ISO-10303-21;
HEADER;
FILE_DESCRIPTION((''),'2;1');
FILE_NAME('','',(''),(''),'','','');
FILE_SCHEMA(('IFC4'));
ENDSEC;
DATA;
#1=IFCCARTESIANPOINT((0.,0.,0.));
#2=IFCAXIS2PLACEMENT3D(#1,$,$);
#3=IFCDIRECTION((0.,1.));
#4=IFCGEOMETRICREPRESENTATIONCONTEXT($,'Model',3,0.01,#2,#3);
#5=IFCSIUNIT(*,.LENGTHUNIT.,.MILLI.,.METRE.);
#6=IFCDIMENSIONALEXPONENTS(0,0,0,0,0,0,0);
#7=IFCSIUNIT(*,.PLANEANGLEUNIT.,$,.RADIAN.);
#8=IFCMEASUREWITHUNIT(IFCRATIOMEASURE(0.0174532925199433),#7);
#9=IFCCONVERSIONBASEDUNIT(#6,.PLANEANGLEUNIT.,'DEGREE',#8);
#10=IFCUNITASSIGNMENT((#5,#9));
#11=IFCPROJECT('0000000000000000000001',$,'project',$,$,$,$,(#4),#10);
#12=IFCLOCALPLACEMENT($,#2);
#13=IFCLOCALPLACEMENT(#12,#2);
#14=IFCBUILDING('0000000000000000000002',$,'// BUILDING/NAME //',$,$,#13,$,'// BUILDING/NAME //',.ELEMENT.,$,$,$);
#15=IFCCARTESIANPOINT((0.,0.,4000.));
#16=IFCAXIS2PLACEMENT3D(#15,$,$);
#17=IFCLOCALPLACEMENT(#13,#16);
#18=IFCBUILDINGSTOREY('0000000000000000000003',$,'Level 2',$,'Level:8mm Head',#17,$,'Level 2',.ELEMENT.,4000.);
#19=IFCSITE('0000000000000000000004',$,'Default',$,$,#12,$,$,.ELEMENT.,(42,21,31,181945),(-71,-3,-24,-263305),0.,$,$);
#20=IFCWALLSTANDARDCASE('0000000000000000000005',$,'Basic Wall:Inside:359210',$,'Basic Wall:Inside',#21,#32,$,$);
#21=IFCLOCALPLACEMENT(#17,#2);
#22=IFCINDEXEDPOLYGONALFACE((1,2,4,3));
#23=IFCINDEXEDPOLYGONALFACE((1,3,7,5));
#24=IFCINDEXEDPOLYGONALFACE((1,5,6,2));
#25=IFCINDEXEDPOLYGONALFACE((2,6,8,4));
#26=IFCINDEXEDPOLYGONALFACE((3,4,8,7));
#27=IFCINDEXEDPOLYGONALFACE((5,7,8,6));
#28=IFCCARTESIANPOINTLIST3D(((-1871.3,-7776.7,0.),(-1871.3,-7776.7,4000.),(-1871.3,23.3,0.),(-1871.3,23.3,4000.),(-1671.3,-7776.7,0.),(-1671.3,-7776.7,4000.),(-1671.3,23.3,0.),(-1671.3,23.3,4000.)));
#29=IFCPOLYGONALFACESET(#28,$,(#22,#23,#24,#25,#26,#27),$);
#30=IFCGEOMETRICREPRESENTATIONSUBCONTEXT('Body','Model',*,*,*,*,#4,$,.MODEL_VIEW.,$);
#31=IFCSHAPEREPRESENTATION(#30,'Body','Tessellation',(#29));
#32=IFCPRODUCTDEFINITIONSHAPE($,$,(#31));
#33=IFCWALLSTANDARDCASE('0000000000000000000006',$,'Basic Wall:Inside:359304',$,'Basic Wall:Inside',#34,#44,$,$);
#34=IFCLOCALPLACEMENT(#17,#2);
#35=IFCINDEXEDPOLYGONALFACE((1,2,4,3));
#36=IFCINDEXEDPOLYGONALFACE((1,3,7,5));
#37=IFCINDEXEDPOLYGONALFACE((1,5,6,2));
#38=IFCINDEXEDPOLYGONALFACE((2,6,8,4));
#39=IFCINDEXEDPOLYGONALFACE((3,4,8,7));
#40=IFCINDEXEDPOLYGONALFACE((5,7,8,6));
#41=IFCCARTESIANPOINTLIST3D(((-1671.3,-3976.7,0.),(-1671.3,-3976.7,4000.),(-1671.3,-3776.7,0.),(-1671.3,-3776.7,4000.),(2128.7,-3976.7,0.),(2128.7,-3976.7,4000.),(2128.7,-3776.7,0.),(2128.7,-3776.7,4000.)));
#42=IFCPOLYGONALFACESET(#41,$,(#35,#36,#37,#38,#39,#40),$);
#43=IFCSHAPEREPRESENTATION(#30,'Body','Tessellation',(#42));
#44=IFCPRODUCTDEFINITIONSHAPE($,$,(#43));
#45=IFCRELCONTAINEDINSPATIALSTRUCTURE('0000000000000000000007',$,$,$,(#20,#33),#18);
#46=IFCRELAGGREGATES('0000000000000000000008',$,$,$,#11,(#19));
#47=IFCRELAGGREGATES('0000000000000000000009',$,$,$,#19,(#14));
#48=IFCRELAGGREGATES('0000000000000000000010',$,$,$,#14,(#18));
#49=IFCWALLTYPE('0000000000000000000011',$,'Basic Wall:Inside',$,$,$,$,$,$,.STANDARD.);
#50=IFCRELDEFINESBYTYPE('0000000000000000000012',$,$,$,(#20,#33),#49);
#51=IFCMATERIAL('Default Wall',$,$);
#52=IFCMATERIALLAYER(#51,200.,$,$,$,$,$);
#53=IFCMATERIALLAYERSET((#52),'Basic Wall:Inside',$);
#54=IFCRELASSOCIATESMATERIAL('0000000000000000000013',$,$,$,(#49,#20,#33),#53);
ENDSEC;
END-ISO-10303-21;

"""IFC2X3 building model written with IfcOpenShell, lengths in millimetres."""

from ifc_helpers import new_model, entity, si_unit, converted_unit, direction, frame, frame_2d, origin, place, context, subcontext, project, spatial, rectangle, extrude, clip, halfspace, material, layer, layer_set, layer_usage, type_object, element, save


model = new_model("IFC2X3")

# Units and contexts
model_context = context("Model", 3, precision=0.01, world=origin(), true_north=direction((0.0, 1.0)))
body_context = subcontext(model_context, "Body", "Model", "MODEL_VIEW")
ifc_project = project(units=[si_unit("LENGTHUNIT", "METRE", prefix="MILLI"), converted_unit("PLANEANGLEUNIT", "DEGREE", entity("IfcRatioMeasure", 0.0174532925199433), si_unit("PLANEANGLEUNIT", "RADIAN"), dimensions=[0, 0, 0, 0, 0, 0, 0])], contexts=[model_context])

# Site, building, storey
site_placement = place(None, origin())
site = spatial("IfcSite", under=ifc_project, at=site_placement, Name="Default", CompositionType="ELEMENT", RefLatitude=(42, 21, 31, 181945), RefLongitude=(-71, -3, -24, -263305), RefElevation=0.0)
building_placement = place(site_placement, origin())
building = spatial("IfcBuilding", under=site, at=building_placement, Name="// BUILDING/NAME //", LongName="// BUILDING/NAME //", CompositionType="ELEMENT")
storey_placement = place(building_placement, frame((0.0, 0.0, 4000.0)))
storey = spatial("IfcBuildingStorey", under=building, at=storey_placement, Name="Level 2", ObjectType="Level:8mm Head", LongName="Level 2", CompositionType="ELEMENT", Elevation=4000.0)

# Shared definitions
ifc_material_1 = material(Name="Default Wall")

# Walls
ifc_layer_1 = layer(ifc_material_1, 200.0)
ifc_layer_set_1 = layer_set([ifc_layer_1], Name="Basic Wall:Inside")
ifc_layer_usage_1 = layer_usage(ifc_layer_set_1, "AXIS2", "NEGATIVE", 100.0)
wall_type_1 = type_object("IfcWallType", Name="Basic Wall:Inside", PredefinedType="STANDARD", material=ifc_layer_set_1)
wall_1_placement = place(storey_placement, frame((-1771.3, 23.3, 0.0), z_axis=(0.0, 0.0, 1.0), x_axis=(0.0, -1.0, 0.0)))
element("IfcWallStandardCase", 1, at=wall_1_placement, inside=storey, type_object=wall_type_1, material=ifc_layer_usage_1, Name="Basic Wall:Inside:359210", ObjectType="Basic Wall:Inside", context=body_context, shape_type="Clipping", body=[
    clip(extrude(rectangle(XDim=7800.0, YDim=200.0, at=frame_2d((3900.0, 0.0), x_axis=(-1.0, 0.0))), origin(), (0.0, 0.0, 1.0), 4000.0), halfspace(frame((0.0, 0.0, -4000.0)), True)),
])
ifc_layer_usage_2 = layer_usage(ifc_layer_set_1, "AXIS2", "NEGATIVE", 100.0)
wall_2_placement = place(storey_placement, frame((-1671.3, -3876.7, 0.0)))
element("IfcWallStandardCase", 2, at=wall_2_placement, inside=storey, type_object=wall_type_1, material=ifc_layer_usage_2, Name="Basic Wall:Inside:359304", ObjectType="Basic Wall:Inside", context=body_context, shape_type="Clipping", body=[
    clip(extrude(rectangle(XDim=3800.0, YDim=200.0, at=frame_2d((1900.0, 0.0), x_axis=(-1.0, 0.0))), origin(), (0.0, 0.0, 1.0), 4000.0), halfspace(frame((0.0, 0.0, -4000.0)), True)),
])

save(model, "model.ifc")
